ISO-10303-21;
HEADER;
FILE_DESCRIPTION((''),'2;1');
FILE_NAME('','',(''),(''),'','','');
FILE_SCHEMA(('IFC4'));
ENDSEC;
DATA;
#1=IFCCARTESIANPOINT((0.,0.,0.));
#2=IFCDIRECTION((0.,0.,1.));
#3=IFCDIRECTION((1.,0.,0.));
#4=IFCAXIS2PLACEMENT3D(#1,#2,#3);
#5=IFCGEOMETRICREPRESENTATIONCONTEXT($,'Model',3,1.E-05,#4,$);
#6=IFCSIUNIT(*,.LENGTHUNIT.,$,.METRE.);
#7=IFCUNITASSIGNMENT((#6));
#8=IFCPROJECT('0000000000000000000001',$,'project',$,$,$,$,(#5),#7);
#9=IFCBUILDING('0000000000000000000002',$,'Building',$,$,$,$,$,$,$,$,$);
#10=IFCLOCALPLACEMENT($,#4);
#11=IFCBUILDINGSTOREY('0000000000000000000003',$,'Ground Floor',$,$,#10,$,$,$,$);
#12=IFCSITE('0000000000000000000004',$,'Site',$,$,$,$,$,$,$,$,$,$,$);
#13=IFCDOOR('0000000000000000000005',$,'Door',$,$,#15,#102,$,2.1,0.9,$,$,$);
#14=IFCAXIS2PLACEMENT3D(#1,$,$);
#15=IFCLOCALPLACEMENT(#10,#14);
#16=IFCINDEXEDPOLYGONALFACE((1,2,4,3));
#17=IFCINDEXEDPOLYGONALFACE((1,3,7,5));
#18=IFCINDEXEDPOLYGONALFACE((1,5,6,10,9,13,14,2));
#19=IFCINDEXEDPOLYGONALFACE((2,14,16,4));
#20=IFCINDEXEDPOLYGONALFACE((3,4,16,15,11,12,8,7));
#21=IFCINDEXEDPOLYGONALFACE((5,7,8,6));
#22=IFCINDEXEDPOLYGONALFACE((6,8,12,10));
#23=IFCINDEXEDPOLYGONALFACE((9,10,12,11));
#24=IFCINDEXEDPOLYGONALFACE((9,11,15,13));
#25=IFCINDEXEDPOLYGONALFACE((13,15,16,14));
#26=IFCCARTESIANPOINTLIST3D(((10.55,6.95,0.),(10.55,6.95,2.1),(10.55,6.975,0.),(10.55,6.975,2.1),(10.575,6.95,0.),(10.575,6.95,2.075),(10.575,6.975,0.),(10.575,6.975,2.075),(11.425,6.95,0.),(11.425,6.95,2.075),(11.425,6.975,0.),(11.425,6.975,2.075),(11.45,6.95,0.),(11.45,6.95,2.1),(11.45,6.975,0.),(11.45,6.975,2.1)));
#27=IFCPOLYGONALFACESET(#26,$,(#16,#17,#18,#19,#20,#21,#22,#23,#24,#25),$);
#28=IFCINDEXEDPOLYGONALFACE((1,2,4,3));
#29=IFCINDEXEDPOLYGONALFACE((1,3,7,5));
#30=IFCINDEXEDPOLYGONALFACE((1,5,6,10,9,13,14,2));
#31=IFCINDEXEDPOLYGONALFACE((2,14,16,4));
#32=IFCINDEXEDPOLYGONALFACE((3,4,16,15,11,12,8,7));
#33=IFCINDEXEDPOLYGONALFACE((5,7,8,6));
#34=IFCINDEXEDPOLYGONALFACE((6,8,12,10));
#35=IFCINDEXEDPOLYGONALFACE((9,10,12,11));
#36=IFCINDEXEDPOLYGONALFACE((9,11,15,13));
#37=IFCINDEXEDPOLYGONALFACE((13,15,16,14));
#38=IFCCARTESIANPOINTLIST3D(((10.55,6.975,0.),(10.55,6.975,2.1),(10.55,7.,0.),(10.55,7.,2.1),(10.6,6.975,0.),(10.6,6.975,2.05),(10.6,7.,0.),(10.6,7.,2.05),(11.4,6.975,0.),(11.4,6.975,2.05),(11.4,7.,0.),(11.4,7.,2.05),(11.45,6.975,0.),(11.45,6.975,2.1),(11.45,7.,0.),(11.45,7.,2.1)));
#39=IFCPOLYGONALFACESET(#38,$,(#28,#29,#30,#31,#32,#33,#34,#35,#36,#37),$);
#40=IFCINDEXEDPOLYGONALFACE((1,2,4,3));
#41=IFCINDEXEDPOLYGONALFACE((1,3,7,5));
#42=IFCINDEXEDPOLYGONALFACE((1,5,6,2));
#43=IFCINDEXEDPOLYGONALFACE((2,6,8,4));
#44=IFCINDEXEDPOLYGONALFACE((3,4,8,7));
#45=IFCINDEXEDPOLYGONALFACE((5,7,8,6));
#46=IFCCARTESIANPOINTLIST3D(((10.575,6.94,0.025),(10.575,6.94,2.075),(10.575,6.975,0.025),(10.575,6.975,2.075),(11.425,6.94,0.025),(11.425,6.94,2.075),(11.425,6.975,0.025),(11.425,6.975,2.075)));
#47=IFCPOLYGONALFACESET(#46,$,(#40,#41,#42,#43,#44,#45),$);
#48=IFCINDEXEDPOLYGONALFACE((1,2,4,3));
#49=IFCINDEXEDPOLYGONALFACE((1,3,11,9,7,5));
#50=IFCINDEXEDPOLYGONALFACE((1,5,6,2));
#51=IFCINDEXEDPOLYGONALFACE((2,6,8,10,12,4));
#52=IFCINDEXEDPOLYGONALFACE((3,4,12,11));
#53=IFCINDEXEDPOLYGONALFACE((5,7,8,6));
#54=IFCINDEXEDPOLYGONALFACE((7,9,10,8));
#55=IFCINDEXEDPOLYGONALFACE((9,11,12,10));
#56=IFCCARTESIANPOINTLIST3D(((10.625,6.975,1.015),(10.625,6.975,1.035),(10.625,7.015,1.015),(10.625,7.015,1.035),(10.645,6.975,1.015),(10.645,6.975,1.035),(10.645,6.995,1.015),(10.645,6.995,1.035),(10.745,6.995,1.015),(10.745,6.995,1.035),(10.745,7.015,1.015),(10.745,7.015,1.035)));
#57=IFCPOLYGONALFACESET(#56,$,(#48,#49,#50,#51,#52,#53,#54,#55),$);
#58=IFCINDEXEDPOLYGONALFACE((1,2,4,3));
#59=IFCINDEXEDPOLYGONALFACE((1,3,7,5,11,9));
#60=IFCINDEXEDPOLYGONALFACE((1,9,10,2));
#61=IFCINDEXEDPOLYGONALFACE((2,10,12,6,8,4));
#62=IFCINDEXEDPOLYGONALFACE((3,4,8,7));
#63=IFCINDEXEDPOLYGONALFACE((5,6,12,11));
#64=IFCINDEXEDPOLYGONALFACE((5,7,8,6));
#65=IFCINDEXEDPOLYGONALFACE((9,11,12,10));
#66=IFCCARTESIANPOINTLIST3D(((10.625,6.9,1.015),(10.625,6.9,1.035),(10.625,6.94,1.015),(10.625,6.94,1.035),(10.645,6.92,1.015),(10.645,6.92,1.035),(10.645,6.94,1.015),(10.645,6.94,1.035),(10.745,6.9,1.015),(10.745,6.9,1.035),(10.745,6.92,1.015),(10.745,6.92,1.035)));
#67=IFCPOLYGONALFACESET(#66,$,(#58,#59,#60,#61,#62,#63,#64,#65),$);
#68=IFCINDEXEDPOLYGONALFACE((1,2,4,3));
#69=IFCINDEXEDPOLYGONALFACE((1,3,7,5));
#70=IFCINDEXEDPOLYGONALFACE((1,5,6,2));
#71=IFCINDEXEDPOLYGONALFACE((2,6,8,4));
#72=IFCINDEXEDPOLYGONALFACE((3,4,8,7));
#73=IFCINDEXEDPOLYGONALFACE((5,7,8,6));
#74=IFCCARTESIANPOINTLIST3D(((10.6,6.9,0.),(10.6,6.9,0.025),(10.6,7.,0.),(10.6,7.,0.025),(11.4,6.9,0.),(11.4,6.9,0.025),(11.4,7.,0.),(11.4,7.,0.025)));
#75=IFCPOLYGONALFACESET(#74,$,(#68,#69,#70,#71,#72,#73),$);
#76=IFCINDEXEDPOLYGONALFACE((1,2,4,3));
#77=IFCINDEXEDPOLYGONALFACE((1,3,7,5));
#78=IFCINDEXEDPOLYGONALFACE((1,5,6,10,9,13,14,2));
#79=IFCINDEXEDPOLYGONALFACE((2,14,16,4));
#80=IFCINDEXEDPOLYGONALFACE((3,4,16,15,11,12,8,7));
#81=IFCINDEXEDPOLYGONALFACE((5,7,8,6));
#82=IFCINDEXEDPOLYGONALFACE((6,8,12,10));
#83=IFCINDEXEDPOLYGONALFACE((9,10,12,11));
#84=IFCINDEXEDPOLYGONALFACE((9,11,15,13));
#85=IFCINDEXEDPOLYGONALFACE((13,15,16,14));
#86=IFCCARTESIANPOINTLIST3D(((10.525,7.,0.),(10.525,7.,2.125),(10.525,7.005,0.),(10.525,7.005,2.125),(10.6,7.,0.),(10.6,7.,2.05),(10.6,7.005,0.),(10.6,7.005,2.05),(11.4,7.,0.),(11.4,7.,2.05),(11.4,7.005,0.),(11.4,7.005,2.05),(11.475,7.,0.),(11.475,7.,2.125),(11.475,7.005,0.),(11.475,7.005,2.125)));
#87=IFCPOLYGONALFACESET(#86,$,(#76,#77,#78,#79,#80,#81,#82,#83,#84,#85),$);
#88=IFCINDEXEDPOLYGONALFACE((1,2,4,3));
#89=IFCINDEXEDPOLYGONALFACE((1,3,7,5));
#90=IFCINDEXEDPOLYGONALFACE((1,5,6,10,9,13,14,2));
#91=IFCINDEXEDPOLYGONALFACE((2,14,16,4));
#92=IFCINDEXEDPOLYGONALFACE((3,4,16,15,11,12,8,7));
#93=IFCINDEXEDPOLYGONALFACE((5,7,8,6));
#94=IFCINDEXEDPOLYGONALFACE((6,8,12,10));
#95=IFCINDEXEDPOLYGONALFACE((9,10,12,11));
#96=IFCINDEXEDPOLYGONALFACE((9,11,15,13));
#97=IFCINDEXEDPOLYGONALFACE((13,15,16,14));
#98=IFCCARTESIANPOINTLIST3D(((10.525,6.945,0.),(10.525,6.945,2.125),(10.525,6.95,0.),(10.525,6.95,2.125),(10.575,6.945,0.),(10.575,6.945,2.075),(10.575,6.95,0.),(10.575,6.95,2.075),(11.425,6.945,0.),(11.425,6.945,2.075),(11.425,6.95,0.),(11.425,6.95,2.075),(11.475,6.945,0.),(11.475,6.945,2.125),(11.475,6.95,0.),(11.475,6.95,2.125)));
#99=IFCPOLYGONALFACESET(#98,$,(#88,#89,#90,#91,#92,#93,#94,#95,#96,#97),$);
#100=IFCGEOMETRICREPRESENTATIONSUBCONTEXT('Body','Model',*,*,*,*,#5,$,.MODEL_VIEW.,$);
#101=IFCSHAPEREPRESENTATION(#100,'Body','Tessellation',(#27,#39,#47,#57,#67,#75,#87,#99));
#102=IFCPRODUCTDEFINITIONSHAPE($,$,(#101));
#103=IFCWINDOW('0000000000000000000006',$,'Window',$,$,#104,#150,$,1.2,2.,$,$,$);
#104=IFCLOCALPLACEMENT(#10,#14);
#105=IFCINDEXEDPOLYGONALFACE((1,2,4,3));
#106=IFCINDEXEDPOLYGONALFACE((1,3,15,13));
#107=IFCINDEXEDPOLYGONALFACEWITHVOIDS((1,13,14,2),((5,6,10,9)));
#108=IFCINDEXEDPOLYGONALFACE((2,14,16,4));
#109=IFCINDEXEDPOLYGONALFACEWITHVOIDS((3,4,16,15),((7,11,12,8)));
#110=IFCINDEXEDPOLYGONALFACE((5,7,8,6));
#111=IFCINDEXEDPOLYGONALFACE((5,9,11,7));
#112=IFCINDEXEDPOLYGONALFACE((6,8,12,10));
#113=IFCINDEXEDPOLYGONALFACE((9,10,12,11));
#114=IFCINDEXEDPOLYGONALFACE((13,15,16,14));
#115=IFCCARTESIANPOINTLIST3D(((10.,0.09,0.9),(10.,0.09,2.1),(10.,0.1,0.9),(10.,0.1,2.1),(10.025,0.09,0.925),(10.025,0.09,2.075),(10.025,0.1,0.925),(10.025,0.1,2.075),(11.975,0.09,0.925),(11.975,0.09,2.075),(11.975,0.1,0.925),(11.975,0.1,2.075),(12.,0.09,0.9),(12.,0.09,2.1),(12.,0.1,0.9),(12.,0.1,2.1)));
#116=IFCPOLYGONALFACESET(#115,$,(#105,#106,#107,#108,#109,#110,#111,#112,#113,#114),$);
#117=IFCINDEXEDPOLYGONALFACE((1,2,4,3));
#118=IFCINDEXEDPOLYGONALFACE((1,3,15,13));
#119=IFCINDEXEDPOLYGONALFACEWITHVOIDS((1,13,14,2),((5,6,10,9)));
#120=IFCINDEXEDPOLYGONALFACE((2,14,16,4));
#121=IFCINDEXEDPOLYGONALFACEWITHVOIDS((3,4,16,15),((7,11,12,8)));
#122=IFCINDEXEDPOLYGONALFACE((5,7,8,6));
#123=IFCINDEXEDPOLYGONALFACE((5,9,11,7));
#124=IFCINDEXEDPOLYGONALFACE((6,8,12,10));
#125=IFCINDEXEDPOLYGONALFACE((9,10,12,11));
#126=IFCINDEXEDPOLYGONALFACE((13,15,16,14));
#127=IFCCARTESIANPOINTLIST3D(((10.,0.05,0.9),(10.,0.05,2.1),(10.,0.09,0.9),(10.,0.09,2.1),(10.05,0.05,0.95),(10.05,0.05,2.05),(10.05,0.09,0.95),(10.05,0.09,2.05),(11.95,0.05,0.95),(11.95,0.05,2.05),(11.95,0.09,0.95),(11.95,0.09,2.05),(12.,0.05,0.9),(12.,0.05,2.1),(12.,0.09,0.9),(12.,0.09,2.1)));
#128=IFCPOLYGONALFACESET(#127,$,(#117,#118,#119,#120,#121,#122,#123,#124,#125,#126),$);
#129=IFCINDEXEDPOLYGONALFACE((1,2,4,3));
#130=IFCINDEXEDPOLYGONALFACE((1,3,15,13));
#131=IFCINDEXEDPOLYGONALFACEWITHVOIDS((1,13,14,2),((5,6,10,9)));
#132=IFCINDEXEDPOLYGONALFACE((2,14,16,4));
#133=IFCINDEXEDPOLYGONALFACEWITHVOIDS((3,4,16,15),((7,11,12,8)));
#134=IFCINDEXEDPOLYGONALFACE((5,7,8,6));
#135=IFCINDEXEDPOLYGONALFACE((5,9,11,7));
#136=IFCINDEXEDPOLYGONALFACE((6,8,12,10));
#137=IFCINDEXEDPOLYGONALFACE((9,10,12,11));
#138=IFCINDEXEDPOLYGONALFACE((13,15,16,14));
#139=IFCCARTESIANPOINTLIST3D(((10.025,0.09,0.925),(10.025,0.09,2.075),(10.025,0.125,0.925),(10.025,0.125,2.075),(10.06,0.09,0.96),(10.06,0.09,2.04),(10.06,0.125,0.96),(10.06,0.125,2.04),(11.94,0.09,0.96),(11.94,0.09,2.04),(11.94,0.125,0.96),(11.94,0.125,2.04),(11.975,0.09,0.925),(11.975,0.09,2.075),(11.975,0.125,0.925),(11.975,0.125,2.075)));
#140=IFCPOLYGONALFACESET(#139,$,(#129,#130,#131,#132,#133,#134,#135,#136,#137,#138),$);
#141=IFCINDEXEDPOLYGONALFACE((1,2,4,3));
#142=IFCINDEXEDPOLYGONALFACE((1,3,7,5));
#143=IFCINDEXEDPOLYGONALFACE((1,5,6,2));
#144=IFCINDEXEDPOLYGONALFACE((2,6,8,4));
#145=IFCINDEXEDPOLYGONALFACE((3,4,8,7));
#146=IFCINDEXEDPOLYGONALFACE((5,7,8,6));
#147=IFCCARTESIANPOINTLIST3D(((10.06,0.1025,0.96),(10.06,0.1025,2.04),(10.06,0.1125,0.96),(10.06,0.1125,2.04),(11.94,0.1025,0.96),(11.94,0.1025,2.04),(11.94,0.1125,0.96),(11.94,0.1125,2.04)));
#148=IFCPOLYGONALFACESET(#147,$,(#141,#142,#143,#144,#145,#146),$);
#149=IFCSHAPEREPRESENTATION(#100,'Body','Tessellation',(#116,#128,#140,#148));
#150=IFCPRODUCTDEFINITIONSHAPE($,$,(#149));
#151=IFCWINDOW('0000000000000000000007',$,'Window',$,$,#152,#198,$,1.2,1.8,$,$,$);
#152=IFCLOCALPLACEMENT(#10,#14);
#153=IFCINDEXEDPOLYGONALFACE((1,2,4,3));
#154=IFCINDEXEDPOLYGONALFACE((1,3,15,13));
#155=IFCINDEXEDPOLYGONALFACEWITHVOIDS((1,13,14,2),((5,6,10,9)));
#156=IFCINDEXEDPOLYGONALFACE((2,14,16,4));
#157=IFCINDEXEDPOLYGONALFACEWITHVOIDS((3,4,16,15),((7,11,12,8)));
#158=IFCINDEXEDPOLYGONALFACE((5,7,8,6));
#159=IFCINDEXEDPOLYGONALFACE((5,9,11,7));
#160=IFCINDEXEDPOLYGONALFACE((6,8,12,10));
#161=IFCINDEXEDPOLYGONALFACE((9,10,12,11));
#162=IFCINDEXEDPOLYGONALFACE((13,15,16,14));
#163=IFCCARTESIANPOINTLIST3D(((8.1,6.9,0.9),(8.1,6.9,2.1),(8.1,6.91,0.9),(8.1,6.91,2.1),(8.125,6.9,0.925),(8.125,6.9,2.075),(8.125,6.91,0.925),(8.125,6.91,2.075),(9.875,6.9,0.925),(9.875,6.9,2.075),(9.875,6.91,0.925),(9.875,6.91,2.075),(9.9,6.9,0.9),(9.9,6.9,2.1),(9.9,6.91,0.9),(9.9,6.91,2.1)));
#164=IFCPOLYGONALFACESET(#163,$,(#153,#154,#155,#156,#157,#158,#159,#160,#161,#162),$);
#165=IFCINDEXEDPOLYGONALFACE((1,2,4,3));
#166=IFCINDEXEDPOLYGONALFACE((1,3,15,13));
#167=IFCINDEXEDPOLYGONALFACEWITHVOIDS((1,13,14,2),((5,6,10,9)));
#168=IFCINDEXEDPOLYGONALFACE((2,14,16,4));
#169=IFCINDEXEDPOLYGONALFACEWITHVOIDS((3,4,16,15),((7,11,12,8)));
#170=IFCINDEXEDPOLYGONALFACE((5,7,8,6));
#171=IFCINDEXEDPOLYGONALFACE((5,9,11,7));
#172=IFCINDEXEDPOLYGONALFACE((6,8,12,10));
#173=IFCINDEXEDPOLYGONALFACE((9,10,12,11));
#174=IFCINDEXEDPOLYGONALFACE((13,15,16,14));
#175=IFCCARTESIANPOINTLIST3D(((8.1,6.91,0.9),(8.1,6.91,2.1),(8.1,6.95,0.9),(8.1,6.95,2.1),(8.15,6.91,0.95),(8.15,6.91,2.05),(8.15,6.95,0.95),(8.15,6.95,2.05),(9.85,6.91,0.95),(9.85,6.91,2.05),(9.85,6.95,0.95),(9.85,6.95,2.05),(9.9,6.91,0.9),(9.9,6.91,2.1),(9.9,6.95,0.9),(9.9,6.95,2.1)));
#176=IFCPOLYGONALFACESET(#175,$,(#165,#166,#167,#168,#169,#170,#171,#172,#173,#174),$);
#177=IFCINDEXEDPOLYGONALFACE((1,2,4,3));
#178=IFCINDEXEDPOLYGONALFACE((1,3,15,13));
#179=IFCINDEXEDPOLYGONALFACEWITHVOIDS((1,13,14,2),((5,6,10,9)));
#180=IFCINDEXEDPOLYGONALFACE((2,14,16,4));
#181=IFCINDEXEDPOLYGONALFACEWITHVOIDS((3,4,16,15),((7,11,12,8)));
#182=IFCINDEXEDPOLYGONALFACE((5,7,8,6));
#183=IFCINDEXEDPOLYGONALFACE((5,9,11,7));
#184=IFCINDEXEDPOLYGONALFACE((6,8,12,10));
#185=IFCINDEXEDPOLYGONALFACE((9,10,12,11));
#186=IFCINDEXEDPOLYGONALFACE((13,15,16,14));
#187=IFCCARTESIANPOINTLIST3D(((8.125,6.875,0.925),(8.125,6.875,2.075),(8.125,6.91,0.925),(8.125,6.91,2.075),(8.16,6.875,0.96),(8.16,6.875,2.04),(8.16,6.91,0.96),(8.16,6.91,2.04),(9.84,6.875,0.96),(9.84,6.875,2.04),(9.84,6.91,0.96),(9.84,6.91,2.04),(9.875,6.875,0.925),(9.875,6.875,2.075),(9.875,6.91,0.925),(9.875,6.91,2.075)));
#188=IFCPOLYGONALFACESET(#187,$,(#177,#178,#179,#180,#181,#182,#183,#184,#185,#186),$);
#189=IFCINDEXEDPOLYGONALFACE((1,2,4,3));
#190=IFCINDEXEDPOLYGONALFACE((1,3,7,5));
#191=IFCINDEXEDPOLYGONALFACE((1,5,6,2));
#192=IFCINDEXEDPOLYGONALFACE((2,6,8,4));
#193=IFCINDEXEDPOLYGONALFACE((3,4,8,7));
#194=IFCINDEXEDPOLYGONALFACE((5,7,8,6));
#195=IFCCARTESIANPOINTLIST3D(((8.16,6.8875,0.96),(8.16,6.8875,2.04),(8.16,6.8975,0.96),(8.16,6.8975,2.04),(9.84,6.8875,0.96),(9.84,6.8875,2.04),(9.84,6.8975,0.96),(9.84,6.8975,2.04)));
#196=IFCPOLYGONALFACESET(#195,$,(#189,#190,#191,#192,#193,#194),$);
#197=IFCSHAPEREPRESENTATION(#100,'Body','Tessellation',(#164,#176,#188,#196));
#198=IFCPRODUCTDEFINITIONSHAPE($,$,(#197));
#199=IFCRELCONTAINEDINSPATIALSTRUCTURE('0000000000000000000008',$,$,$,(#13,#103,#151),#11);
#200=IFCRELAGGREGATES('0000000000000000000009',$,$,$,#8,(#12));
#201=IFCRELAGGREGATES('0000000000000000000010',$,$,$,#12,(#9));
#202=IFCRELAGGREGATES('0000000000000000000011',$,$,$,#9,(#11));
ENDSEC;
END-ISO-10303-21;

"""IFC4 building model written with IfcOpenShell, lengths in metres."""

from ifc_helpers import new_model, si_unit, frame, origin_with_axes, place, context, subcontext, project, spatial, line, indexed_curve, outline, extrude, element, save


model = new_model("IFC4")

# Units and contexts
model_context = context("Model", 3, precision=1e-05, world=origin_with_axes())
body_context = subcontext(model_context, "Body", "Model", "MODEL_VIEW")
ifc_project = project(units=[si_unit("LENGTHUNIT", "METRE")], contexts=[model_context])

# Site, building, storey
site = spatial("IfcSite", under=ifc_project, Name="Site")
building = spatial("IfcBuilding", under=site, Name="Building")
storey_placement = place(None, origin_with_axes())
storey = spatial("IfcBuildingStorey", under=building, at=storey_placement, Name="Ground Floor")

# Door
door_1_placement = place(storey_placement, frame((11.45, 7.0, 0.0), z_axis=(0.0, 0.0, 1.0), x_axis=(-1.0, 0.0, 0.0)))
element("IfcDoor", 1, at=door_1_placement, inside=storey, Name="Door", OverallHeight=2.1, OverallWidth=0.9, context=body_context, shape_type="SweptSolid", body=[
    extrude(outline(indexed_curve([(0.0, 0.0), (0.0, 2.1), (0.9, 2.1), (0.9, 0.0), (0.875, 0.0), (0.875, 2.075), (0.025, 2.075), (0.025, 0.0)], segments=[line(1, 2, 3, 4, 5, 6, 7, 8, 1)])), frame((0.0, 0.025, 0.0), z_axis=(0.0, -1.0, 0.0), x_axis=(1.0, 0.0, 0.0)), (0.0, 0.0, -1.0), 0.025),
    extrude(outline(indexed_curve([(0.0, 0.0), (0.0, 2.1), (0.9, 2.1), (0.9, 0.0), (0.85, 0.0), (0.85, 2.05), (0.05, 2.05), (0.05, 0.0)], segments=[line(1, 2, 3, 4, 5, 6, 7, 8, 1)])), frame((0.0, 0.0, 0.0), z_axis=(0.0, -1.0, 0.0), x_axis=(1.0, 0.0, 0.0)), (0.0, 0.0, -1.0), 0.025),
    extrude(outline(indexed_curve([(0.0, 0.0), (0.85, 0.0), (0.85, 0.035), (0.0, 0.035)], segments=[line(1, 2, 3, 4, 1)])), frame((0.025, 0.025, 0.025), z_axis=(0.0, 0.0, 1.0), x_axis=(1.0, 0.0, 0.0)), (0.0, 0.0, 1.0), 2.05),
    extrude(outline(indexed_curve([(0.0, 0.0), (0.0, -0.04), (-0.12, -0.04), (-0.12, -0.02), (-0.02, -0.02), (-0.02, 0.0)], segments=[line(1, 2, 3, 4, 5, 6, 1)])), frame((0.825, 0.025, 1.015), z_axis=(0.0, 0.0, 1.0), x_axis=(1.0, 0.0, 0.0)), (0.0, 0.0, 1.0), 0.02),
    extrude(outline(indexed_curve([(0.0, 0.0), (0.0, 0.04), (-0.12, 0.04), (-0.12, 0.02), (-0.02, 0.02), (-0.02, 0.0)], segments=[line(1, 2, 3, 4, 5, 6, 1)])), frame((0.825, 0.06, 1.015), z_axis=(0.0, 0.0, 1.0), x_axis=(1.0, 0.0, 0.0)), (0.0, 0.0, 1.0), 0.02),
    extrude(outline(indexed_curve([(0.0, 0.0), (0.8, 0.0), (0.8, 0.1), (0.0, 0.1)], segments=[line(1, 2, 3, 4, 1)])), frame((0.05, 0.0, 0.0), z_axis=(0.0, 0.0, 1.0), x_axis=(1.0, 0.0, 0.0)), (0.0, 0.0, 1.0), 0.025),
    extrude(outline(indexed_curve([(0.0, 0.0), (0.0, 2.125), (0.95, 2.125), (0.95, 0.0), (0.875, 0.0), (0.875, 2.05), (0.075, 2.05), (0.075, 0.0)], segments=[line(1, 2, 3, 4, 5, 6, 7, 8, 1)])), frame((-0.025, -0.005, 0.0), z_axis=(0.0, -1.0, 0.0), x_axis=(1.0, 0.0, 0.0)), (0.0, 0.0, -1.0), 0.005),
    extrude(outline(indexed_curve([(0.0, 0.0), (0.0, 2.125), (0.95, 2.125), (0.95, 0.0), (0.9, 0.0), (0.9, 2.075), (0.05, 2.075), (0.05, 0.0)], segments=[line(1, 2, 3, 4, 5, 6, 7, 8, 1)])), frame((-0.025, 0.05, 0.0), z_axis=(0.0, -1.0, 0.0), x_axis=(1.0, 0.0, 0.0)), (0.0, 0.0, -1.0), 0.005),
])

# Windows
window_1_placement = place(storey_placement, frame((10.0, 0.0, 0.9), z_axis=(0.0, 0.0, 1.0), x_axis=(1.0, 0.0, 0.0)))
element("IfcWindow", 2, at=window_1_placement, inside=storey, Name="Window", OverallHeight=1.2, OverallWidth=2.0, context=body_context, shape_type="SweptSolid", body=[
    extrude(outline(indexed_curve([(0.0, 0.0), (2.0, 0.0), (2.0, 1.2), (0.0, 1.2)], segments=[line(1, 2, 3, 4, 1)]), holes=[indexed_curve([(0.025, 0.025), (1.975, 0.025), (1.975, 1.175), (0.025, 1.175)], segments=[line(1, 2, 3, 4, 1)])]), frame((0.0, 0.09, 0.0), z_axis=(0.0, -1.0, 0.0), x_axis=(1.0, 0.0, 0.0)), (0.0, 0.0, -1.0), 0.01),
    extrude(outline(indexed_curve([(0.0, 0.0), (2.0, 0.0), (2.0, 1.2), (0.0, 1.2)], segments=[line(1, 2, 3, 4, 1)]), holes=[indexed_curve([(0.05, 0.05), (1.95, 0.05), (1.95, 1.15), (0.05, 1.15)], segments=[line(1, 2, 3, 4, 1)])]), frame((0.0, 0.05, 0.0), z_axis=(0.0, -1.0, 0.0), x_axis=(1.0, 0.0, 0.0)), (0.0, 0.0, -1.0), 0.04),
    extrude(outline(indexed_curve([(0.0, 0.0), (1.95, 0.0), (1.95, 1.15), (0.0, 1.15)], segments=[line(1, 2, 3, 4, 1)]), holes=[indexed_curve([(0.035, 0.035), (1.915, 0.035), (1.915, 1.115), (0.035, 1.115)], segments=[line(1, 2, 3, 4, 1)])]), frame((0.025, 0.09, 0.025), z_axis=(0.0, -1.0, 0.0), x_axis=(1.0, 0.0, 0.0)), (0.0, 0.0, -1.0), 0.035),
    extrude(outline(indexed_curve([(0.035, 0.035), (1.915, 0.035), (1.915, 1.115), (0.035, 1.115)], segments=[line(1, 2, 3, 4, 1)])), frame((0.025, 0.1025, 0.025), z_axis=(0.0, -1.0, 0.0), x_axis=(1.0, 0.0, 0.0)), (0.0, 0.0, -1.0), 0.01),
])
window_2_placement = place(storey_placement, frame((9.9, 7.0, 0.9), z_axis=(0.0, 0.0, 1.0), x_axis=(-1.0, 0.0, 0.0)))
element("IfcWindow", 3, at=window_2_placement, inside=storey, Name="Window", OverallHeight=1.2, OverallWidth=1.8, context=body_context, shape_type="SweptSolid", body=[
    extrude(outline(indexed_curve([(0.0, 0.0), (1.8, 0.0), (1.8, 1.2), (0.0, 1.2)], segments=[line(1, 2, 3, 4, 1)]), holes=[indexed_curve([(0.025, 0.025), (1.775, 0.025), (1.775, 1.175), (0.025, 1.175)], segments=[line(1, 2, 3, 4, 1)])]), frame((0.0, 0.09, 0.0), z_axis=(0.0, -1.0, 0.0), x_axis=(1.0, 0.0, 0.0)), (0.0, 0.0, -1.0), 0.01),
    extrude(outline(indexed_curve([(0.0, 0.0), (1.8, 0.0), (1.8, 1.2), (0.0, 1.2)], segments=[line(1, 2, 3, 4, 1)]), holes=[indexed_curve([(0.05, 0.05), (1.75, 0.05), (1.75, 1.15), (0.05, 1.15)], segments=[line(1, 2, 3, 4, 1)])]), frame((0.0, 0.05, 0.0), z_axis=(0.0, -1.0, 0.0), x_axis=(1.0, 0.0, 0.0)), (0.0, 0.0, -1.0), 0.04),
    extrude(outline(indexed_curve([(0.0, 0.0), (1.75, 0.0), (1.75, 1.15), (0.0, 1.15)], segments=[line(1, 2, 3, 4, 1)]), holes=[indexed_curve([(0.035, 0.035), (1.715, 0.035), (1.715, 1.115), (0.035, 1.115)], segments=[line(1, 2, 3, 4, 1)])]), frame((0.025, 0.09, 0.025), z_axis=(0.0, -1.0, 0.0), x_axis=(1.0, 0.0, 0.0)), (0.0, 0.0, -1.0), 0.035),
    extrude(outline(indexed_curve([(0.035, 0.035), (1.715, 0.035), (1.715, 1.115), (0.035, 1.115)], segments=[line(1, 2, 3, 4, 1)])), frame((0.025, 0.1025, 0.025), z_axis=(0.0, -1.0, 0.0), x_axis=(1.0, 0.0, 0.0)), (0.0, 0.0, -1.0), 0.01),
])

save(model, "model.ifc")
